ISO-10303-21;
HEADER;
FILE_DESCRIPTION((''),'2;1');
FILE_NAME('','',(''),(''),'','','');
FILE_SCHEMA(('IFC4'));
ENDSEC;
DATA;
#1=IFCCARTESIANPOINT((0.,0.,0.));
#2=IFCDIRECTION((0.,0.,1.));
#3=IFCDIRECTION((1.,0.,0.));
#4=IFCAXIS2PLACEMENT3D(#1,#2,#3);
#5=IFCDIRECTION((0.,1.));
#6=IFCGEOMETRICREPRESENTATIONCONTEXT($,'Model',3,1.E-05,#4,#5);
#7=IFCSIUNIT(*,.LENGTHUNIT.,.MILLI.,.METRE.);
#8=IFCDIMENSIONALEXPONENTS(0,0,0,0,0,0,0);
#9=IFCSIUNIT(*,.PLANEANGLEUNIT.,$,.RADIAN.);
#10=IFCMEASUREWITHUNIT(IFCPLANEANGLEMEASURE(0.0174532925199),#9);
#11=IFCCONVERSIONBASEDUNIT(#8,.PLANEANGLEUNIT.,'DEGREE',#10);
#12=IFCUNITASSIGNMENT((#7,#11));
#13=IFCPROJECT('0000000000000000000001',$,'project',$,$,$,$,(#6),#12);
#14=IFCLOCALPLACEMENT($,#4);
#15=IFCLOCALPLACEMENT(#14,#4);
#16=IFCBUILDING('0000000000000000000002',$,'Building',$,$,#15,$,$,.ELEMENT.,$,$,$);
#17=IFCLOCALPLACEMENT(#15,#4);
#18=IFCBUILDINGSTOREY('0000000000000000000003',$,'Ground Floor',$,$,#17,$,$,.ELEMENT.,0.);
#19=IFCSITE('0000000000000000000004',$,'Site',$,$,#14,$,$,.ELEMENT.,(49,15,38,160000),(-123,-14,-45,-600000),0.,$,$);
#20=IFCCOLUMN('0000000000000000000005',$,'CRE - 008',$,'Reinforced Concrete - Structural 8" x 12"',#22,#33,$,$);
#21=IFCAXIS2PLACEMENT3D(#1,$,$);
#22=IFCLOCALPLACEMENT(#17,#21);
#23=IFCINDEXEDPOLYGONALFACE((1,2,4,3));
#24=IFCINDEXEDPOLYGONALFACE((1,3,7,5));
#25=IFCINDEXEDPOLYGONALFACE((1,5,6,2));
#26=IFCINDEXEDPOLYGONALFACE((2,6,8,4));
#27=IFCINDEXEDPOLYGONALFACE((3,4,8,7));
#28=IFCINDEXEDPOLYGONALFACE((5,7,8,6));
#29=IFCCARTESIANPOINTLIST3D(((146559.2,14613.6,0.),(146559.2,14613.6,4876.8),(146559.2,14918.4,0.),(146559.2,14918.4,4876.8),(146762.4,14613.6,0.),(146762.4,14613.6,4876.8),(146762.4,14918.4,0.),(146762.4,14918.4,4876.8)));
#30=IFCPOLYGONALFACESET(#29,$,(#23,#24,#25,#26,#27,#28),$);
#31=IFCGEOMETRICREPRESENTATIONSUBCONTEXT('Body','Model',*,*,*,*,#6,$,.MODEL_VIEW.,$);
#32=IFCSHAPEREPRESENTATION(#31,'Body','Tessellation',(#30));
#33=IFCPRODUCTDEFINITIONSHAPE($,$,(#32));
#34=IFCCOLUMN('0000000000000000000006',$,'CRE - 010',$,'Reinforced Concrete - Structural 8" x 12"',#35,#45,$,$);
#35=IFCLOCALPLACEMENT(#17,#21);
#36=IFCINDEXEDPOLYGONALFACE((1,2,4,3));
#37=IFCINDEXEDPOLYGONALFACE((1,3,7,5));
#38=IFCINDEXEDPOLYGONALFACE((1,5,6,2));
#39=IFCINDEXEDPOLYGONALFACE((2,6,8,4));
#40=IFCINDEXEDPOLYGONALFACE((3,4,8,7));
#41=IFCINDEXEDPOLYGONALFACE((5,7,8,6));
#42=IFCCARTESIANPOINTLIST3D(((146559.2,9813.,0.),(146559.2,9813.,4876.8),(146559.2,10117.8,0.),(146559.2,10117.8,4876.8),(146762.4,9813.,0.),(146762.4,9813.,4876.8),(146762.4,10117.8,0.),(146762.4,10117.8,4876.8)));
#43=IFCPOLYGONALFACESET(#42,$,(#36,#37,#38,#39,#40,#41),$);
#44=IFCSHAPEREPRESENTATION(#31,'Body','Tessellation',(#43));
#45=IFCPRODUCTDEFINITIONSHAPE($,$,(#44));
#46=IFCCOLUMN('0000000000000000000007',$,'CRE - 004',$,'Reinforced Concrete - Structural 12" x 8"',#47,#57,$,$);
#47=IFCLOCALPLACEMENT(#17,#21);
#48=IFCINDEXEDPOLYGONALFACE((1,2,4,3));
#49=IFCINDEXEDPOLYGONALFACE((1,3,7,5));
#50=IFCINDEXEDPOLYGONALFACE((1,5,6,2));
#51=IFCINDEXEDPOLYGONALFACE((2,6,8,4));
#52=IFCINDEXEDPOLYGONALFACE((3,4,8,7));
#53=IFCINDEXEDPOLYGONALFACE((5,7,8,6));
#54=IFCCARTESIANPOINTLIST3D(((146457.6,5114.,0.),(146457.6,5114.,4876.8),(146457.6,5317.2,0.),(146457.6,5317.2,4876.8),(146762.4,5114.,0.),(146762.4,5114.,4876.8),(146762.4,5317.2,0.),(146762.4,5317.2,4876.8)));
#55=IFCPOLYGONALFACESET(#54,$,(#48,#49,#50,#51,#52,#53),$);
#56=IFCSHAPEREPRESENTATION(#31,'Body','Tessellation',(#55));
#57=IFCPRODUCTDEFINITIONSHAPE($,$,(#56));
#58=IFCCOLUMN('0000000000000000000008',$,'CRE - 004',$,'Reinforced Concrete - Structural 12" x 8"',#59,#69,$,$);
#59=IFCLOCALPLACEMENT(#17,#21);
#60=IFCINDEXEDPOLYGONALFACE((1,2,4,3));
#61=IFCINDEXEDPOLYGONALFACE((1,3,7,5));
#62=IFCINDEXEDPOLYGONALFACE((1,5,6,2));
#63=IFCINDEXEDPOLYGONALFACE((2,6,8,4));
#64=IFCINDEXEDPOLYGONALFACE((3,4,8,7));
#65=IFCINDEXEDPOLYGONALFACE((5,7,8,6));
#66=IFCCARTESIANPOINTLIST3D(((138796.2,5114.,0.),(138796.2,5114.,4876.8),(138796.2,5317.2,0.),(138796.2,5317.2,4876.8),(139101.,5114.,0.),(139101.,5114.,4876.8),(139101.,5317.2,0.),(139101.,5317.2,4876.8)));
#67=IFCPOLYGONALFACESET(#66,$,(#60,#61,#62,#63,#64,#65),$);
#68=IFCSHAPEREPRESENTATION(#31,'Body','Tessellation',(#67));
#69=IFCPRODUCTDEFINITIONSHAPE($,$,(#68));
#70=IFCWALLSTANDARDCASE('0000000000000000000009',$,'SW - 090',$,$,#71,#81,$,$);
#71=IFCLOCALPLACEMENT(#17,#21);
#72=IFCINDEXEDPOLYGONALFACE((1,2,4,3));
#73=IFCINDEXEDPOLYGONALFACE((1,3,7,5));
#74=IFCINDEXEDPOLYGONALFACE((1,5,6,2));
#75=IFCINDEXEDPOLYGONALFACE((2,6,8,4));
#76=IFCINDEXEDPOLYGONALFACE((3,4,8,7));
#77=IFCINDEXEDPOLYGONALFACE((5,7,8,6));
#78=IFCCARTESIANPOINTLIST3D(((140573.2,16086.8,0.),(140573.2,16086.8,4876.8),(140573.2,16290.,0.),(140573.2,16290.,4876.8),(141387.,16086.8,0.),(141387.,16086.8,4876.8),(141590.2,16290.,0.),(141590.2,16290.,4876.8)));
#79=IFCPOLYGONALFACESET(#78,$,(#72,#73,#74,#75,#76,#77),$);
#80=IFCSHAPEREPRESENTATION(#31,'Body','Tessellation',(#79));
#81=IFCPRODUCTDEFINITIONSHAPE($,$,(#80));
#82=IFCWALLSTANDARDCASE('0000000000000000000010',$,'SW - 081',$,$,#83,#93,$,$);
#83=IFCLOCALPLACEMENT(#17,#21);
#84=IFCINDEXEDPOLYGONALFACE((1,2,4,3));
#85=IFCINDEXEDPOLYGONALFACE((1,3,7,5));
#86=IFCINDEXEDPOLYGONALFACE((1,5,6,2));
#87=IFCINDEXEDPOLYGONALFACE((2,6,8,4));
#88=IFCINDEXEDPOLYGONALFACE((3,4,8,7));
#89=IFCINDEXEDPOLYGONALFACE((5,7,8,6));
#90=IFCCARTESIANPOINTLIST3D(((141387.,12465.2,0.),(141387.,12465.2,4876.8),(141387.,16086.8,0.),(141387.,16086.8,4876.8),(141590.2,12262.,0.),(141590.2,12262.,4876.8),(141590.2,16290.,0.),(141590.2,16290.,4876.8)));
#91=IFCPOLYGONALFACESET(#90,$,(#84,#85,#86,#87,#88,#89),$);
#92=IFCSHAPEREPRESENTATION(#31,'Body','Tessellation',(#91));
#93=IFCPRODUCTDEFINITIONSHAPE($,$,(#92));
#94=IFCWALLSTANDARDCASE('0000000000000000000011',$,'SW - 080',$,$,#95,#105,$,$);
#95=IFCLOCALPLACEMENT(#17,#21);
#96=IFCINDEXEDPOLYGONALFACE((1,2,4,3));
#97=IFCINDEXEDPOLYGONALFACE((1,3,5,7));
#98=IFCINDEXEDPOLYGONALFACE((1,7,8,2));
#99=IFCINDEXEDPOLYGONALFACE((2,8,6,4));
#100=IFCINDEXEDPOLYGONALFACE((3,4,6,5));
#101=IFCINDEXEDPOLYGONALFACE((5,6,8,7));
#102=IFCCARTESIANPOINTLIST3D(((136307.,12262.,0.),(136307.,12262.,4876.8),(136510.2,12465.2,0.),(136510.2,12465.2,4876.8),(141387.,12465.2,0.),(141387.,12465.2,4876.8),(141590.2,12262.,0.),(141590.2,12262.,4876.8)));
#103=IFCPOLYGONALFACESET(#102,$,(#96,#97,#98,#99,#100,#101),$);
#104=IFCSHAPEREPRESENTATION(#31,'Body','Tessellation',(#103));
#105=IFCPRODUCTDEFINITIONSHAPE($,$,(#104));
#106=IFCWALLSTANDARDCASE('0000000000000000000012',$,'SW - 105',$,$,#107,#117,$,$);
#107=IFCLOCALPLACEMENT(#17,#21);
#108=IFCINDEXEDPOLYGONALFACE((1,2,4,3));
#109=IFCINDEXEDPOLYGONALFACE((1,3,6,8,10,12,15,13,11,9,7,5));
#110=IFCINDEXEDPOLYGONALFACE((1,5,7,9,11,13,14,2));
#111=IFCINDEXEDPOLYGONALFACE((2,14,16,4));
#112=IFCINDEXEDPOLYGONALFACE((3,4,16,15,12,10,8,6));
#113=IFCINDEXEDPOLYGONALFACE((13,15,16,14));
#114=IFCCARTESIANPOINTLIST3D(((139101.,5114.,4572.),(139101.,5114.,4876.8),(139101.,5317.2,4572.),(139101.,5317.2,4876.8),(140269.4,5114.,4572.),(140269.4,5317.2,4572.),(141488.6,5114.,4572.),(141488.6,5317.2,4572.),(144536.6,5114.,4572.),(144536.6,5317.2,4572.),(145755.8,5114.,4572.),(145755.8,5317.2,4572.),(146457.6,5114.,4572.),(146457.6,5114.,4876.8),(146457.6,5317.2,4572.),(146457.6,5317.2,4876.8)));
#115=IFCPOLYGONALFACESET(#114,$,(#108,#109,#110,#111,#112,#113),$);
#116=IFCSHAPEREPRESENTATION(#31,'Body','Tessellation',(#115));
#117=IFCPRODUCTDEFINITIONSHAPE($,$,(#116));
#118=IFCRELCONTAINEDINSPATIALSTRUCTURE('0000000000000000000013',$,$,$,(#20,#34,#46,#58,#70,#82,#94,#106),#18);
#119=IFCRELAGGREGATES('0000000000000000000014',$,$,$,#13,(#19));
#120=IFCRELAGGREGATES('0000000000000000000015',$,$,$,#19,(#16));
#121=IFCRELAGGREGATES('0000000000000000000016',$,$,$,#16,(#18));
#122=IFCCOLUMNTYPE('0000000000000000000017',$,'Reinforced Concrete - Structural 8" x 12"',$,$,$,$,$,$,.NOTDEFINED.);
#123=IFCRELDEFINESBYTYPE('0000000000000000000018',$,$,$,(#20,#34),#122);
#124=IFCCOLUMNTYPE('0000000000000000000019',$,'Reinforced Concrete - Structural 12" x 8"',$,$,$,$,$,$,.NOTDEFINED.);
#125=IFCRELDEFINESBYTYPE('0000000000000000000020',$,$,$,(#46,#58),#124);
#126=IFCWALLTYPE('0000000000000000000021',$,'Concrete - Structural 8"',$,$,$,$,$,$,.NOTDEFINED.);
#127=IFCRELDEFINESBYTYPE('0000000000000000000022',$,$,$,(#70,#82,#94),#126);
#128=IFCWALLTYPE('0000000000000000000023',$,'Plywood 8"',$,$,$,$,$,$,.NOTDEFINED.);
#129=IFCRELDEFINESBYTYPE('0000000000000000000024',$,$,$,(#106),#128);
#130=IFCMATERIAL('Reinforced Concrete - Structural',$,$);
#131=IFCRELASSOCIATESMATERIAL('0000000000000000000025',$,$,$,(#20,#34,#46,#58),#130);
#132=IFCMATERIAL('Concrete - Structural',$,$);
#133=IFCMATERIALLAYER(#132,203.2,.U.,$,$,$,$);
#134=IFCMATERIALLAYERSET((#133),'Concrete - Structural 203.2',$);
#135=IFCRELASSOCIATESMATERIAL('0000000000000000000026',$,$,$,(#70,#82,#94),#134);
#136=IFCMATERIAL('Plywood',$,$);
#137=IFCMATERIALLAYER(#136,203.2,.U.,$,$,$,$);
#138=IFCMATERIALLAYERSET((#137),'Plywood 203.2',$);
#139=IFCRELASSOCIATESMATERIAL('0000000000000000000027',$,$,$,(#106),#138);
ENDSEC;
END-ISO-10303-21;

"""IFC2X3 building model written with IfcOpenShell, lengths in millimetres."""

from ifc_helpers import new_model, entity, si_unit, converted_unit, direction, frame, origin_with_axes, origin_2d_with_axis, place, context, subcontext, project, spatial, polyline, rectangle, outline, extrude, material, layer, layer_set, layer_usage, type_object, element, save


model = new_model("IFC2X3")

# Units and contexts
model_context = context("Model", 3, precision=1e-05, world=origin_with_axes(), true_north=direction((0.0, 1.0)))
body_context = subcontext(model_context, "Body", "Model", "MODEL_VIEW")
ifc_project = project(units=[si_unit("LENGTHUNIT", "METRE", prefix="MILLI"), converted_unit("PLANEANGLEUNIT", "DEGREE", entity("IfcPlaneAngleMeasure", 0.0174532925199), si_unit("PLANEANGLEUNIT", "RADIAN"), dimensions=[0, 0, 0, 0, 0, 0, 0])], contexts=[model_context])

# Site, building, storey
site_placement = place(None, origin_with_axes())
site = spatial("IfcSite", under=ifc_project, at=site_placement, Name="Site", CompositionType="ELEMENT", RefLatitude=(49, 15, 38, 160000), RefLongitude=(-123, -14, -45, -600000), RefElevation=0.0)
building_placement = place(site_placement, origin_with_axes())
building = spatial("IfcBuilding", under=site, at=building_placement, Name="Building", CompositionType="ELEMENT")
storey_placement = place(building_placement, origin_with_axes())
storey = spatial("IfcBuildingStorey", under=building, at=storey_placement, Name="Ground Floor", CompositionType="ELEMENT", Elevation=0.0)

# Columns
ifc_material_1 = material(Name="Reinforced Concrete - Structural")
column_type_1 = type_object("IfcColumnType", Name="Reinforced Concrete - Structural 8\" x 12\"", PredefinedType="NOTDEFINED")
for number, where, z_axis, x_axis, name in (
    (1, (146660.8, 14766.0, 0.0), (0.0, 0.0, 1.0), (1.0, 0.0, 0.0), "CRE - 008"),
    (2, (146660.8, 9965.4, 0.0), (0.0, 0.0, 1.0), (1.0, 0.0, 0.0), "CRE - 010"),
):
    element("IfcColumn", number, at=place(storey_placement, frame(where, z_axis=z_axis, x_axis=x_axis)), inside=storey, type_object=column_type_1, material=ifc_material_1, Name=name, ObjectType="Reinforced Concrete - Structural 8\" x 12\"", context=body_context, shape_type="SweptSolid", body=[
        extrude(rectangle(XDim=203.2, YDim=304.8, at=origin_2d_with_axis()), origin_with_axes(), (0.0, 0.0, 1.0), 4876.8),
    ])
column_type_2 = type_object("IfcColumnType", Name="Reinforced Concrete - Structural 12\" x 8\"", PredefinedType="NOTDEFINED")
for number, where, z_axis, x_axis, name in (
    (3, (146610.0, 5215.6, 0.0), (0.0, 0.0, 1.0), (1.0, 0.0, 0.0), "CRE - 004"),
    (4, (138948.6, 5215.6, 0.0), (0.0, 0.0, 1.0), (1.0, 0.0, 0.0), "CRE - 004"),
):
    element("IfcColumn", number, at=place(storey_placement, frame(where, z_axis=z_axis, x_axis=x_axis)), inside=storey, type_object=column_type_2, material=ifc_material_1, Name=name, ObjectType="Reinforced Concrete - Structural 12\" x 8\"", context=body_context, shape_type="SweptSolid", body=[
        extrude(rectangle(XDim=304.8, YDim=203.2, at=origin_2d_with_axis()), origin_with_axes(), (0.0, 0.0, 1.0), 4876.8),
    ])

# Walls
ifc_material_2 = material(Name="Concrete - Structural")
ifc_layer_1 = layer(ifc_material_2, 203.2, ventilated="UNKNOWN")
ifc_layer_set_1 = layer_set([ifc_layer_1], Name="Concrete - Structural 203.2")
ifc_layer_usage_1 = layer_usage(ifc_layer_set_1, "AXIS2", "NEGATIVE", 0.0)
wall_type_1 = type_object("IfcWallType", Name="Concrete - Structural 8\"", PredefinedType="NOTDEFINED")
wall_1_placement = place(storey_placement, frame((141387.0, 16086.8, 0.0), z_axis=(0.0, 0.0, 1.0), x_axis=(-1.0, 0.0, 0.0)))
element("IfcWallStandardCase", 5, at=wall_1_placement, inside=storey, type_object=wall_type_1, material=ifc_layer_usage_1, Name="SW - 090", context=body_context, shape_type="SweptSolid", body=[
    extrude(outline(polyline([(-203.2, -203.2), (813.8, -203.2), (813.8, 0.0), (0.0, 0.0), (-203.2, -203.2)])), origin_with_axes(), (0.0, 0.0, 1.0), 4876.8),
])
ifc_layer_usage_2 = layer_usage(ifc_layer_set_1, "AXIS2", "NEGATIVE", 0.0)
wall_2_placement = place(storey_placement, frame((141387.0, 12465.2, 0.0), z_axis=(0.0, 0.0, 1.0), x_axis=(0.0, 1.0, 0.0)))
element("IfcWallStandardCase", 6, at=wall_2_placement, inside=storey, type_object=wall_type_1, material=ifc_layer_usage_2, Name="SW - 081", context=body_context, shape_type="SweptSolid", body=[
    extrude(outline(polyline([(-203.2, -203.2), (3824.8, -203.2), (3621.6, 0.0), (0.0, 0.0), (-203.2, -203.2)])), origin_with_axes(), (0.0, 0.0, 1.0), 4876.8),
])
ifc_layer_usage_3 = layer_usage(ifc_layer_set_1, "AXIS2", "NEGATIVE", 0.0)
wall_3_placement = place(storey_placement, frame((136510.2, 12465.2, 0.0), z_axis=(0.0, 0.0, 1.0), x_axis=(1.0, 0.0, 0.0)))
element("IfcWallStandardCase", 7, at=wall_3_placement, inside=storey, type_object=wall_type_1, material=ifc_layer_usage_3, Name="SW - 080", context=body_context, shape_type="SweptSolid", body=[
    extrude(outline(polyline([(-203.2, -203.2), (5080.0, -203.2), (4876.8, 0.0), (0.0, 0.0), (-203.2, -203.2)])), origin_with_axes(), (0.0, 0.0, 1.0), 4876.8),
])

# Wall, openings
ifc_material_3 = material(Name="Plywood")
ifc_layer_2 = layer(ifc_material_3, 203.2, ventilated="UNKNOWN")
ifc_layer_set_2 = layer_set([ifc_layer_2], Name="Plywood 203.2")
ifc_layer_usage_4 = layer_usage(ifc_layer_set_2, "AXIS2", "NEGATIVE", 0.0)
wall_type_2 = type_object("IfcWallType", Name="Plywood 8\"", PredefinedType="NOTDEFINED")
wall_4_placement = place(storey_placement, frame((139101.0, 5317.2, 0.0), z_axis=(0.0, 0.0, 1.0), x_axis=(1.0, 0.0, 0.0)))
wall_4 = element("IfcWallStandardCase", 8, at=wall_4_placement, inside=storey, type_object=wall_type_2, material=ifc_layer_usage_4, Name="SW - 105", context=body_context, shape_type="SweptSolid", body=[
    extrude(outline(polyline([(0.0, -203.2), (7356.6, -203.2), (7356.6, 0.0), (0.0, 0.0), (0.0, -203.2)])), origin_with_axes(), (0.0, 0.0, 1.0), 4876.8),
])
opening_1_placement = place(wall_4_placement, frame((6045.2, 0.0, 0.0), z_axis=(0.0, 0.0, 1.0), x_axis=(1.0, 0.0, 0.0)))
element("IfcOpeningElement", 9, at=opening_1_placement, cuts=wall_4, context=body_context, shape_type="SweptSolid", body=[
    extrude(rectangle(XDim=1219.2, YDim=4572.0, at=origin_2d_with_axis()), frame((0.0, 203.2, 2286.0), z_axis=(0.0, -1.0, 0.0), x_axis=(-1.0, 0.0, 0.0)), (0.0, 0.0, 1.0), 609.6),
])
opening_2_placement = place(wall_4_placement, frame((7005.7, 0.0, 0.0), z_axis=(0.0, 0.0, 1.0), x_axis=(1.0, 0.0, 0.0)))
element("IfcOpeningElement", 10, at=opening_2_placement, cuts=wall_4, context=body_context, shape_type="SweptSolid", body=[
    extrude(rectangle(XDim=701.8, YDim=4572.0, at=origin_2d_with_axis()), frame((0.0, 203.2, 2286.0), z_axis=(0.0, -1.0, 0.0), x_axis=(-1.0, 0.0, 0.0)), (0.0, 0.0, 1.0), 609.6),
])
opening_3_placement = place(wall_4_placement, frame((1778.0, 0.0, 0.0), z_axis=(0.0, 0.0, 1.0), x_axis=(1.0, 0.0, 0.0)))
element("IfcOpeningElement", 11, at=opening_3_placement, cuts=wall_4, context=body_context, shape_type="SweptSolid", body=[
    extrude(rectangle(XDim=1219.2, YDim=4572.0, at=origin_2d_with_axis()), frame((0.0, 203.2, 2286.0), z_axis=(0.0, 1.0, 0.0), x_axis=(1.0, 0.0, 0.0)), (0.0, 0.0, -1.0), 609.6),
])
opening_4_placement = place(wall_4_placement, frame((584.2, 0.0, 0.0), z_axis=(0.0, 0.0, 1.0), x_axis=(1.0, 0.0, 0.0)))
element("IfcOpeningElement", 12, at=opening_4_placement, cuts=wall_4, context=body_context, shape_type="SweptSolid", body=[
    extrude(rectangle(XDim=1168.4, YDim=4572.0, at=origin_2d_with_axis()), frame((0.0, 203.2, 2286.0), z_axis=(0.0, -1.0, 0.0), x_axis=(-1.0, 0.0, 0.0)), (0.0, 0.0, 1.0), 609.6),
])
opening_5_placement = place(wall_4_placement, frame((3911.6, 0.0, 0.0), z_axis=(0.0, 0.0, 1.0), x_axis=(1.0, 0.0, 0.0)))
element("IfcOpeningElement", 13, at=opening_5_placement, cuts=wall_4, context=body_context, shape_type="SweptSolid", body=[
    extrude(rectangle(XDim=3048.0, YDim=4572.0, at=origin_2d_with_axis()), frame((0.0, 203.2, 2286.0), z_axis=(0.0, -1.0, 0.0), x_axis=(-1.0, 0.0, 0.0)), (0.0, 0.0, 1.0), 609.6),
])

save(model, "model.ifc")
